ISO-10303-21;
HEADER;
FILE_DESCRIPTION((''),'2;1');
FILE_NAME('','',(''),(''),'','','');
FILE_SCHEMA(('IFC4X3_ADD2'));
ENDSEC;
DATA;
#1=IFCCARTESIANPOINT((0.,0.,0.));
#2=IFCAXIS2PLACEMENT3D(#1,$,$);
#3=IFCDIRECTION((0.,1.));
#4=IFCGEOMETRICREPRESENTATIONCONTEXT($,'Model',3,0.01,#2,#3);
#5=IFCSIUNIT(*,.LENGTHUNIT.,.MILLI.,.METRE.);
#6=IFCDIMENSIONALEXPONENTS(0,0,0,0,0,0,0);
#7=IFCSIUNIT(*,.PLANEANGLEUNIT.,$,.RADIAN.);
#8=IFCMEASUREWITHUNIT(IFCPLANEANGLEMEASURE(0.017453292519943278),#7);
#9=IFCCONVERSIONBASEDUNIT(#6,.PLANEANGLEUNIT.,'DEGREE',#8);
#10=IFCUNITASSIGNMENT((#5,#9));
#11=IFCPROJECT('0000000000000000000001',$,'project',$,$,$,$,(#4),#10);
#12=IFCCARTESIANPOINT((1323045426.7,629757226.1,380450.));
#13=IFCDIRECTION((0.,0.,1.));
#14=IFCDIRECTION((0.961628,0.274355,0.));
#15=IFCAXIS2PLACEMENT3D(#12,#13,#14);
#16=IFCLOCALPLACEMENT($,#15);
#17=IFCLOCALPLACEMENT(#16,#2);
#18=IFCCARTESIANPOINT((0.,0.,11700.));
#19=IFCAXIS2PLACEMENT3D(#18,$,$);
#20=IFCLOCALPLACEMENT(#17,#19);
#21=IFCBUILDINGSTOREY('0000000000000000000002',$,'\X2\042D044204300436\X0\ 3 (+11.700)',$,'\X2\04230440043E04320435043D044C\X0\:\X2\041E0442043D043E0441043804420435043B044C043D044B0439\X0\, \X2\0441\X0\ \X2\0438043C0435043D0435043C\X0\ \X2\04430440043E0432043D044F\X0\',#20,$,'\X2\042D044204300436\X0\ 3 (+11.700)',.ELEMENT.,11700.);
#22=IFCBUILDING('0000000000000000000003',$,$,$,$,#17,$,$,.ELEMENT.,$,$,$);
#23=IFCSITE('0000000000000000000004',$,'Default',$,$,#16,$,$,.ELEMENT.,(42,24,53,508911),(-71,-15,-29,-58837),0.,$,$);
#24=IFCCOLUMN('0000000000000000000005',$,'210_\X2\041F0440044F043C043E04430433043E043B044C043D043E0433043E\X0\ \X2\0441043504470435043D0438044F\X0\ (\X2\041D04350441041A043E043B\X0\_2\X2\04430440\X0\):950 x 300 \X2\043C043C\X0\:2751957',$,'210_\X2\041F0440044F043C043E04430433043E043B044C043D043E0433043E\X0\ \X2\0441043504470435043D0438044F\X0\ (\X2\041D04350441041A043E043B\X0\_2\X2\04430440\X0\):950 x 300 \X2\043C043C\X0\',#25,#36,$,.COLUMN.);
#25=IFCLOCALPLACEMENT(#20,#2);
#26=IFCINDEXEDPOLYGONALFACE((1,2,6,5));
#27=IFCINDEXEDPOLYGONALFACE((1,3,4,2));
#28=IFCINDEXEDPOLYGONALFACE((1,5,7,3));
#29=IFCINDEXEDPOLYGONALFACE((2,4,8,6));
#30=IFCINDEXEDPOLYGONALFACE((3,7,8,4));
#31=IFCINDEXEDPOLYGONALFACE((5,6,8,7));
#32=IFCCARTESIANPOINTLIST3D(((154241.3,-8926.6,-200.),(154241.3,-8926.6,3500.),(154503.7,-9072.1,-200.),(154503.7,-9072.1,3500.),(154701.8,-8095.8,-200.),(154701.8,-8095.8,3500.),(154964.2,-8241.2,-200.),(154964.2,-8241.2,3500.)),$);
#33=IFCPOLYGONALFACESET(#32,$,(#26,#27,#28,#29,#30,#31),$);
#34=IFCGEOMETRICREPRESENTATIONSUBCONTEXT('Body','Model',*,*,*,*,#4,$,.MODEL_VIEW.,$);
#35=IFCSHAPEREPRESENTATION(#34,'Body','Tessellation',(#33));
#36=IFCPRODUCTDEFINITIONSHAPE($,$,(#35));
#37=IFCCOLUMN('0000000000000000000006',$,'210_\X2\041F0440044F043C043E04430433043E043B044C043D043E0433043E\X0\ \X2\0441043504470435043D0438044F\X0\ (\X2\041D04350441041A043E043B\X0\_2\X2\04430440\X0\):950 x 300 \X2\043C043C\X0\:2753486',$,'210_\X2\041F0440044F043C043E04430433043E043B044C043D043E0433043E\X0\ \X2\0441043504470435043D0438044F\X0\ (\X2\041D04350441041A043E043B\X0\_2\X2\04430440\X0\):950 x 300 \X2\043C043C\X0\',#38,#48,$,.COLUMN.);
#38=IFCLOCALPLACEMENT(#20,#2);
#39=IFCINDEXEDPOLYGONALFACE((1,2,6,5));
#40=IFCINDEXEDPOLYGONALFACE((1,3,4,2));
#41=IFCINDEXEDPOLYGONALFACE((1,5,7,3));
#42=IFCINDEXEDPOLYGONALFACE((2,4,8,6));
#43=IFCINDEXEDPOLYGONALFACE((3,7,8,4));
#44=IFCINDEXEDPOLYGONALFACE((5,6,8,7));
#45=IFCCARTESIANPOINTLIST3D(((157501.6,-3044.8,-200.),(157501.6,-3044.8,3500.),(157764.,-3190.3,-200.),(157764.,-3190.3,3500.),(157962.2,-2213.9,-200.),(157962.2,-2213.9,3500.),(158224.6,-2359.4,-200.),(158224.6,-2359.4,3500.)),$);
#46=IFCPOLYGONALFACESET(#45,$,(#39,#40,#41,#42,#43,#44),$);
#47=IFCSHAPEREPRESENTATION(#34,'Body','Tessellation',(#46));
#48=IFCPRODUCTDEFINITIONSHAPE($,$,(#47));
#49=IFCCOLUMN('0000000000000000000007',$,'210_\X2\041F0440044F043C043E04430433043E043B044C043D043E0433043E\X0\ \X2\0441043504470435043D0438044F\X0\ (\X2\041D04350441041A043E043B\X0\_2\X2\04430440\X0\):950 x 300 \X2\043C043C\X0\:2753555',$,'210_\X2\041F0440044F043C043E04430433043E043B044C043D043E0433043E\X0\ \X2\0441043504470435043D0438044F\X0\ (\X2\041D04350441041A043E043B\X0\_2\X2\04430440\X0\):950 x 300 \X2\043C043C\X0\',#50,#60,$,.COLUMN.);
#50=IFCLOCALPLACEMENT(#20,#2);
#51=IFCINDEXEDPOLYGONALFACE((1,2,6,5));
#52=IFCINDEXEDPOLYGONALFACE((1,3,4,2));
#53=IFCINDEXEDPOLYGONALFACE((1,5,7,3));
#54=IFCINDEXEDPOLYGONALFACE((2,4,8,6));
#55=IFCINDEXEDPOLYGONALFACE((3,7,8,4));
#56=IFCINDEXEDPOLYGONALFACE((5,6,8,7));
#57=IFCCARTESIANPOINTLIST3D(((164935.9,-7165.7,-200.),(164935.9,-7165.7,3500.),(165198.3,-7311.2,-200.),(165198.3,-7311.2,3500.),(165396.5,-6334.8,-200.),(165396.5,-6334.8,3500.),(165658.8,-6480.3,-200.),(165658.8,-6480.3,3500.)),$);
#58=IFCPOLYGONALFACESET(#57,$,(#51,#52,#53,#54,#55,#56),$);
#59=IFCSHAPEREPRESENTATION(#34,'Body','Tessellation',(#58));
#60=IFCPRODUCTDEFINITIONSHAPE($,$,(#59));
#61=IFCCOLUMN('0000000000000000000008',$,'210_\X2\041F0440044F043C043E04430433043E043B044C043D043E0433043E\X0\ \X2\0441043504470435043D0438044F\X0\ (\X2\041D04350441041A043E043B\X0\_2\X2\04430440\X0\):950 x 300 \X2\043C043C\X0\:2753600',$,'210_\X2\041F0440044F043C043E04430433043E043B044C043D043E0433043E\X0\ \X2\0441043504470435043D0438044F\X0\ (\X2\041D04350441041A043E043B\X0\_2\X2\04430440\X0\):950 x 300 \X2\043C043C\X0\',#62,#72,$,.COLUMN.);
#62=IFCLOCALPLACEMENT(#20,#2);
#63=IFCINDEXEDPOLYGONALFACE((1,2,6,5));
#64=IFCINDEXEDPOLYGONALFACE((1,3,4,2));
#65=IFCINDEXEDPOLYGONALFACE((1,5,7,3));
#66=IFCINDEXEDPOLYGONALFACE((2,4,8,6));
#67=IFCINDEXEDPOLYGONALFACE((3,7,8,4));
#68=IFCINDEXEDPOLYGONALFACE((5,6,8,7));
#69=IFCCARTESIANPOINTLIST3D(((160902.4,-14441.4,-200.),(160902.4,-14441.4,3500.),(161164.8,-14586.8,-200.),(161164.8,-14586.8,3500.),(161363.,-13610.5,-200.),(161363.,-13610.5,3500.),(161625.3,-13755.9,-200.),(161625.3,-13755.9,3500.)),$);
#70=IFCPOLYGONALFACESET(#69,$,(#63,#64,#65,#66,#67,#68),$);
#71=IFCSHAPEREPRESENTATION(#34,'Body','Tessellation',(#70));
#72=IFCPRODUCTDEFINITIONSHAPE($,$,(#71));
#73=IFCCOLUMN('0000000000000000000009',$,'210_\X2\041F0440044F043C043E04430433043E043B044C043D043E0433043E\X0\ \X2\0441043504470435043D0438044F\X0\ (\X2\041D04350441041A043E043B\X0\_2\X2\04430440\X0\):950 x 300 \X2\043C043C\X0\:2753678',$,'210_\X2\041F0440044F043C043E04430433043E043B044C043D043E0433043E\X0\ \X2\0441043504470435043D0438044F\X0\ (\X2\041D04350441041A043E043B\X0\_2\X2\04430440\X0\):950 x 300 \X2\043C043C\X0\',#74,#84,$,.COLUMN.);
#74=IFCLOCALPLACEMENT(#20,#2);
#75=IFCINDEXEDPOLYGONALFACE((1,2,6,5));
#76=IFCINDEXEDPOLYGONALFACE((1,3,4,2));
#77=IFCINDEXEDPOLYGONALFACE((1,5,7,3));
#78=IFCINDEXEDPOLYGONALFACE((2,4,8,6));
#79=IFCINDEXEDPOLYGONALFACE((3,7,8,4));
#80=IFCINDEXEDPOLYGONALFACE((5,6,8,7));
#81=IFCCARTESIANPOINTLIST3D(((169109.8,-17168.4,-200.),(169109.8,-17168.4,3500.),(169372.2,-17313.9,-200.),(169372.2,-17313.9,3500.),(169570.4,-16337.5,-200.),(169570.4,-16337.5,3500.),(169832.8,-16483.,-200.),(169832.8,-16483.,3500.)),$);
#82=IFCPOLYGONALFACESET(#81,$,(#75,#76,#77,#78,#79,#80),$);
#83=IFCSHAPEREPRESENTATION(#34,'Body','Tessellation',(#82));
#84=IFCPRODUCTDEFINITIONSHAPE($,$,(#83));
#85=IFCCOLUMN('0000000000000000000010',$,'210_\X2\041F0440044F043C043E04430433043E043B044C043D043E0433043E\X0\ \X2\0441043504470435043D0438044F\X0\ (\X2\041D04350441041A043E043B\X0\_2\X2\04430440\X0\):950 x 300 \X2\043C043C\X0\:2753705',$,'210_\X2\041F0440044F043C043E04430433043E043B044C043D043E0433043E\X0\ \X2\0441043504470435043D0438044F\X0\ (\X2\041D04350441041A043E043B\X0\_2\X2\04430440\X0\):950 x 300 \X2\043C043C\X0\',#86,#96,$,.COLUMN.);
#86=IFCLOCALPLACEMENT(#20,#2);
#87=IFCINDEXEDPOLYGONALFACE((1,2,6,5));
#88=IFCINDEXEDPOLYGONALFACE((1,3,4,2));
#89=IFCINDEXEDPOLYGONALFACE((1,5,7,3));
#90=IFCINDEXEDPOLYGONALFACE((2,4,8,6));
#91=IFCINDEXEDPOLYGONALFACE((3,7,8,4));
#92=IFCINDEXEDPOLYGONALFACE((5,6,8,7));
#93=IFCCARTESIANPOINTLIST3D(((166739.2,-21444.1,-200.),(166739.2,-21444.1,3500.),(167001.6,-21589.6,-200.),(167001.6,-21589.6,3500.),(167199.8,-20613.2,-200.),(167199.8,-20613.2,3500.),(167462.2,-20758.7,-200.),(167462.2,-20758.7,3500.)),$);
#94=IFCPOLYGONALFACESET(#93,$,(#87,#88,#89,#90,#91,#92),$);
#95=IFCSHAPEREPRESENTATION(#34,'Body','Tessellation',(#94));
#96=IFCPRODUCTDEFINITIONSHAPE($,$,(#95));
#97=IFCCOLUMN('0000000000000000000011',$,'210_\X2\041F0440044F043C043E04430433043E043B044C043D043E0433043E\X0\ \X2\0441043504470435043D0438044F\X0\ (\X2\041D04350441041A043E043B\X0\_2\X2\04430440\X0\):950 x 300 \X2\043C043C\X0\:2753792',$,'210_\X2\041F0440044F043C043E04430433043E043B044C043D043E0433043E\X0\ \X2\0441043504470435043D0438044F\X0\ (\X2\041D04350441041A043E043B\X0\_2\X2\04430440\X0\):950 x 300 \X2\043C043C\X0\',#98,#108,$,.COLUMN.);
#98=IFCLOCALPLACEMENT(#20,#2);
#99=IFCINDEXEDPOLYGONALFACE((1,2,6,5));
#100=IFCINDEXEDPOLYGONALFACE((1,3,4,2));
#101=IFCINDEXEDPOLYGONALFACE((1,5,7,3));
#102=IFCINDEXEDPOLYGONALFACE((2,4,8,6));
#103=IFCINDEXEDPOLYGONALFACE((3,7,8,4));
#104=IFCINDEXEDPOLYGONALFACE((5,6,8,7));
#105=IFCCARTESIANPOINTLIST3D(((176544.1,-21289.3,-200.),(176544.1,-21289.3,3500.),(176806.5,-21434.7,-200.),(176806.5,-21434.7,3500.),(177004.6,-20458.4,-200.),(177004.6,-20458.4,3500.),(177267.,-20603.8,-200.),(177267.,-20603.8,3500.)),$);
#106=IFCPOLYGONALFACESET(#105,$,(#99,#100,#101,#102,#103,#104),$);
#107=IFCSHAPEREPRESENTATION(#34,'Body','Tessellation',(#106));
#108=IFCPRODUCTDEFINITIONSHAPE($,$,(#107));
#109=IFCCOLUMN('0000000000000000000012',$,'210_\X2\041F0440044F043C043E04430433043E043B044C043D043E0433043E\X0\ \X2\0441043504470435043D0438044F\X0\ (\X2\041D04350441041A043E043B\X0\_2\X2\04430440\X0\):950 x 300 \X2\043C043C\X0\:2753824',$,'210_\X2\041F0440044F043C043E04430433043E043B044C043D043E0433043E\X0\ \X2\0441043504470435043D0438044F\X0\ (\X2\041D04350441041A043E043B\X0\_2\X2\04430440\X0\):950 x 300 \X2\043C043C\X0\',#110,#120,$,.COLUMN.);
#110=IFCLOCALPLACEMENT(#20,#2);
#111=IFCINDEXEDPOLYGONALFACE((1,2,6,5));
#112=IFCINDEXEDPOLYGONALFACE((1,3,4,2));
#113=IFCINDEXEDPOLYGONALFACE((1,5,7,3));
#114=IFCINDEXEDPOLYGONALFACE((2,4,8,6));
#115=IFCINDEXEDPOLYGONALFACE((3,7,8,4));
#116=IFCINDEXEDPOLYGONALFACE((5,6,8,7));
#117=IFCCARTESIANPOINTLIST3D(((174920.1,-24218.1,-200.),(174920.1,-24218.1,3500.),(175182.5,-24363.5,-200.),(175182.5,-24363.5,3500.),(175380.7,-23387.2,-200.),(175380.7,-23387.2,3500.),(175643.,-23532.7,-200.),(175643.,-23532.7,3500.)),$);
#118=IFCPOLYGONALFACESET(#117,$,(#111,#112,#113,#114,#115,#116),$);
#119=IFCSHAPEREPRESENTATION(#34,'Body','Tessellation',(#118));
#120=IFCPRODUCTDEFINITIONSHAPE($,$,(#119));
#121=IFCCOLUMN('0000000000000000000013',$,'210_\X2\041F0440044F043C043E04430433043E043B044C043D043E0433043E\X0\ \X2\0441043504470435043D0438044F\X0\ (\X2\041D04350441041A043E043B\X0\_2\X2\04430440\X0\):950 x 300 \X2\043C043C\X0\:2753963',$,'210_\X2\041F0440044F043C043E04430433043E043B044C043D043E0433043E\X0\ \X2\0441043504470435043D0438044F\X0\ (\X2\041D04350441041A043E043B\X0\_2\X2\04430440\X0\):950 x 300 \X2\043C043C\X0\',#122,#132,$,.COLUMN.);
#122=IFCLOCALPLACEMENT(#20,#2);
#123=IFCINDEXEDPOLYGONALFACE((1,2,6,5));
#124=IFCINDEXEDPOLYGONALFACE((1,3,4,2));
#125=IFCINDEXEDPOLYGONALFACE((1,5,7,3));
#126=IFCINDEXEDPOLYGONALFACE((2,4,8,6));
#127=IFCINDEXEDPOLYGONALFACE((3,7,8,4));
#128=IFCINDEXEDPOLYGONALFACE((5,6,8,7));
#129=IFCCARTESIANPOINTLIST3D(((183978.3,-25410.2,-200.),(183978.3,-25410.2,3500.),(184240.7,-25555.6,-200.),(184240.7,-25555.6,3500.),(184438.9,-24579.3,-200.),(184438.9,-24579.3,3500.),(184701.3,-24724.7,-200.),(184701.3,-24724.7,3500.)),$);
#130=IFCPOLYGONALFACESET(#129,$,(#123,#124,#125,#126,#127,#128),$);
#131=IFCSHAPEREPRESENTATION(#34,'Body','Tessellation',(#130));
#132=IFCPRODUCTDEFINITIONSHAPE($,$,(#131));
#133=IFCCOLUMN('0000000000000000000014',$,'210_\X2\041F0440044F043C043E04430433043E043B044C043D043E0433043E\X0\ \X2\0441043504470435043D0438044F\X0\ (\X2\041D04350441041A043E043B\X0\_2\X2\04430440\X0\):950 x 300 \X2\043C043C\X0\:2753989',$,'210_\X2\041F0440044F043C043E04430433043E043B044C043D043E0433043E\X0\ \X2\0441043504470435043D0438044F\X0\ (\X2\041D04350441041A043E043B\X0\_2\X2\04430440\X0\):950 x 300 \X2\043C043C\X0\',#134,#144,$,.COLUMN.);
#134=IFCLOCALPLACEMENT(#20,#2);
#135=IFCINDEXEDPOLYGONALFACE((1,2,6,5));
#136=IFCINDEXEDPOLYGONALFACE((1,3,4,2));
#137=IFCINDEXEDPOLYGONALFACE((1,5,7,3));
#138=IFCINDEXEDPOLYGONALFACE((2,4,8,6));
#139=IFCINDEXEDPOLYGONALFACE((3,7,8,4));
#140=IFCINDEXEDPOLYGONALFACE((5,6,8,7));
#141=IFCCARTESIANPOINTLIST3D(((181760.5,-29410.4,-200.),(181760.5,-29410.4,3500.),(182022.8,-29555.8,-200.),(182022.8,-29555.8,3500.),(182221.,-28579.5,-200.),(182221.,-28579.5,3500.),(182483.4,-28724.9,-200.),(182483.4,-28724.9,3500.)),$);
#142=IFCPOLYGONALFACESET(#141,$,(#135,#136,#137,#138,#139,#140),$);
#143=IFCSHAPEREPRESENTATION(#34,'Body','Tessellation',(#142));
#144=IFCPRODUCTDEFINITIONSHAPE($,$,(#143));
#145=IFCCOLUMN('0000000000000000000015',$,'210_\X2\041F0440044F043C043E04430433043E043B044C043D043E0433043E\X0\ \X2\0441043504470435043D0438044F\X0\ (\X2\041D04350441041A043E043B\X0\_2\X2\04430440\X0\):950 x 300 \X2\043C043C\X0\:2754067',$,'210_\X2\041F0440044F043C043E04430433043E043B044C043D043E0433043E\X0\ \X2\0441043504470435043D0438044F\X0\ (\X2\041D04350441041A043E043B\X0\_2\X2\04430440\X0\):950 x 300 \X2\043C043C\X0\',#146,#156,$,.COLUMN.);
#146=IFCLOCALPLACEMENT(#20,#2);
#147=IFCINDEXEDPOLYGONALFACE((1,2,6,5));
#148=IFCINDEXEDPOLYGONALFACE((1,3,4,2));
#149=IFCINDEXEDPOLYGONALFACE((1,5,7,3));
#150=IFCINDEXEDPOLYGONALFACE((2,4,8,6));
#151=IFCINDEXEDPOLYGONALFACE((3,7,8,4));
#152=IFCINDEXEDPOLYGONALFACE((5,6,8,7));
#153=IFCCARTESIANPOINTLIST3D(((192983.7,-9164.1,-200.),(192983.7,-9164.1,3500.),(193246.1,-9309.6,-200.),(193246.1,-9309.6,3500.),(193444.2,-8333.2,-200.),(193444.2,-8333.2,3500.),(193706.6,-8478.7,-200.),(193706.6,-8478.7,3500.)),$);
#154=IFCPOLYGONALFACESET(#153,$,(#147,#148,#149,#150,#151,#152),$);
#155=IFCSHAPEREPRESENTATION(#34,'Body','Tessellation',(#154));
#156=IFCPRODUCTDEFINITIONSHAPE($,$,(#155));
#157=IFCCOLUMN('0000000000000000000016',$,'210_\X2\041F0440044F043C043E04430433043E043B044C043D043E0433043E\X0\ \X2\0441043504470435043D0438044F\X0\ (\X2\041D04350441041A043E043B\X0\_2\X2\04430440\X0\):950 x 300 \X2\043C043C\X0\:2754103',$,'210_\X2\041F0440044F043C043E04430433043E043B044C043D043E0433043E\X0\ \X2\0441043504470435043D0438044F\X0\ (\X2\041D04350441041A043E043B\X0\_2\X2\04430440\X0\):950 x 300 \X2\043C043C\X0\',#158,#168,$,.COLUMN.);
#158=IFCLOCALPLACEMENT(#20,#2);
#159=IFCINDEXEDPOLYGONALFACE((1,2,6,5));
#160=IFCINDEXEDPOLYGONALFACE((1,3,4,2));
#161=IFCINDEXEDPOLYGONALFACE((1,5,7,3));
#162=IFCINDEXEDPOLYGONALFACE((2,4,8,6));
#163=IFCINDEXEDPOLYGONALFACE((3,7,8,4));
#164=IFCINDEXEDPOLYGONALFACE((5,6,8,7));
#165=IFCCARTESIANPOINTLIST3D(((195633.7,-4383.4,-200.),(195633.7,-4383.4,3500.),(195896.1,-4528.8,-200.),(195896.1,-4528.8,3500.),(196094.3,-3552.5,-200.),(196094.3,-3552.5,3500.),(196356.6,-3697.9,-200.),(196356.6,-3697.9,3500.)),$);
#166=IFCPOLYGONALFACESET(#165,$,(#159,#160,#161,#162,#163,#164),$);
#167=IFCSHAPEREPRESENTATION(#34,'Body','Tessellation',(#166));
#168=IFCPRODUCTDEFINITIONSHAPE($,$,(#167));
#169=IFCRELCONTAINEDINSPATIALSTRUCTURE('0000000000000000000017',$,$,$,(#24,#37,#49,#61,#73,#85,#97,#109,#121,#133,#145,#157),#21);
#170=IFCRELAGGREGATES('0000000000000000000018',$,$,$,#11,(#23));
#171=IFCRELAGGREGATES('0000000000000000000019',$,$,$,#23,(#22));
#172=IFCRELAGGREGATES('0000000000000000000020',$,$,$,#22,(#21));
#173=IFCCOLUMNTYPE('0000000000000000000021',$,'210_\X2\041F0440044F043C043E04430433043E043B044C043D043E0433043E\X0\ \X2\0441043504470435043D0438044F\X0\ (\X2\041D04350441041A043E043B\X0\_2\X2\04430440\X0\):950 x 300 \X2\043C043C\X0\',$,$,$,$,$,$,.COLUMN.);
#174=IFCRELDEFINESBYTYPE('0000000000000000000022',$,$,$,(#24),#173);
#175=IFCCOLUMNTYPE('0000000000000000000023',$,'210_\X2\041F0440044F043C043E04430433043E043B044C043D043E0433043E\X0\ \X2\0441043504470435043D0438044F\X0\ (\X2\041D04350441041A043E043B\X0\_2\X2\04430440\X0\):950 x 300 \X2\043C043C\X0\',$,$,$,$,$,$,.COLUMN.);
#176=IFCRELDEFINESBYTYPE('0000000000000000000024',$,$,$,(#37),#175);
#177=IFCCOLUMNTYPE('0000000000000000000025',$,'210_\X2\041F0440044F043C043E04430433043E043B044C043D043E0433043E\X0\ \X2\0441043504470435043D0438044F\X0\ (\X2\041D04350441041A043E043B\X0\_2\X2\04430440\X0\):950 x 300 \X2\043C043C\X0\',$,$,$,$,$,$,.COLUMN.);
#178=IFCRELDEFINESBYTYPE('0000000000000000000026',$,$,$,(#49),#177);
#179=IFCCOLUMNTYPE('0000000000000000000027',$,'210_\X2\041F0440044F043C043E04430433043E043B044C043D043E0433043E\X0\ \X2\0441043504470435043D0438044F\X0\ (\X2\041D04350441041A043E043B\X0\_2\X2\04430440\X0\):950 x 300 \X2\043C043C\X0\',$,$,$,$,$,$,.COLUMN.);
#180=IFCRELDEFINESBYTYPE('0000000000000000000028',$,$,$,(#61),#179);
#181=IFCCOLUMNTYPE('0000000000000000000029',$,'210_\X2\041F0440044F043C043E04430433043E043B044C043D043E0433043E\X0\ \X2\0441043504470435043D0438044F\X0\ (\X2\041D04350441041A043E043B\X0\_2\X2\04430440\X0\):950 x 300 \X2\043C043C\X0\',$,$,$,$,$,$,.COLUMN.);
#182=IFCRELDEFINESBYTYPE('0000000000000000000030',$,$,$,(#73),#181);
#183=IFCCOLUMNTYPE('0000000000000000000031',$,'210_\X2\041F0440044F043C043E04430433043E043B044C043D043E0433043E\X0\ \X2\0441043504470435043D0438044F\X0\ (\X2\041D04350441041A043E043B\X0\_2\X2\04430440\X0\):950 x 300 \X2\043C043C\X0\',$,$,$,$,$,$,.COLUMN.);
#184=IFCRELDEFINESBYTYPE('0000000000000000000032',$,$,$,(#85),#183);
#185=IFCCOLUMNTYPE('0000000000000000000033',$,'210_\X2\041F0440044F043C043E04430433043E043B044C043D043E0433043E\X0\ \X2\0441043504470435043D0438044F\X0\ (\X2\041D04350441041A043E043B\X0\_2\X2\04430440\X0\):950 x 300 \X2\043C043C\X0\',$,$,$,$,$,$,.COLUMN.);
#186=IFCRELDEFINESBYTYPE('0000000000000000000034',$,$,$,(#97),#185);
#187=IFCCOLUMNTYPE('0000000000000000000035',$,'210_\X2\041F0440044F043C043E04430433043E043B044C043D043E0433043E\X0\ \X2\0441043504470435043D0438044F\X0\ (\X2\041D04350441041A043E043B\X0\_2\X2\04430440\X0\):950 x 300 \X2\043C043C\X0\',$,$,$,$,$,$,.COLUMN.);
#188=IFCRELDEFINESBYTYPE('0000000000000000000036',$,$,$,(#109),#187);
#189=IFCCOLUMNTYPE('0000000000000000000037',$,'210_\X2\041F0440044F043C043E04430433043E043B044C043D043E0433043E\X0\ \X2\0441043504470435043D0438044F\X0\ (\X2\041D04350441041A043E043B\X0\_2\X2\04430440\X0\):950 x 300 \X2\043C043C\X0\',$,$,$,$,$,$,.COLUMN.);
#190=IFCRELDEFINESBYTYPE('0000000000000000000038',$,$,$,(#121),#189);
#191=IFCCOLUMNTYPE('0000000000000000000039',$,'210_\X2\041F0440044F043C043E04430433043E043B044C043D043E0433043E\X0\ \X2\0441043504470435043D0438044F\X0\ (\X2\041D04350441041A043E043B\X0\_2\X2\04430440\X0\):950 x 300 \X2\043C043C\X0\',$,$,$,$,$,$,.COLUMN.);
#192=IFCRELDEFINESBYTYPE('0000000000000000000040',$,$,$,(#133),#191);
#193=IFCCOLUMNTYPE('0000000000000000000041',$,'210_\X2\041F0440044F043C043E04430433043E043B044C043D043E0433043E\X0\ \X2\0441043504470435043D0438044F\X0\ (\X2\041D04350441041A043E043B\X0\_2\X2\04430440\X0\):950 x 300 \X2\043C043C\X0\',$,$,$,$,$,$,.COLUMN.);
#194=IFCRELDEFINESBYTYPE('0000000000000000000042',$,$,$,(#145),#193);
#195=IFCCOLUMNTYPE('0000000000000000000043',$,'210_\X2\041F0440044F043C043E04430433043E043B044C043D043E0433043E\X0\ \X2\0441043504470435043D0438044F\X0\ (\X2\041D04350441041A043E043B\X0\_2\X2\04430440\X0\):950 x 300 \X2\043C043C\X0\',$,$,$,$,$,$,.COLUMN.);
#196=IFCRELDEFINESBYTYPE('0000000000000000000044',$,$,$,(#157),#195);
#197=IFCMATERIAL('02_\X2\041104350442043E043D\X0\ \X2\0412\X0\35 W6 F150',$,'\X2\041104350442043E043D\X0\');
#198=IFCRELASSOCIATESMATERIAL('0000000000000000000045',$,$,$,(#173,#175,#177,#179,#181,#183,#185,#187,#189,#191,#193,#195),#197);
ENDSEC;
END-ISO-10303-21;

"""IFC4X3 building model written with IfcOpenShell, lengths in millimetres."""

from ifc_helpers import new_model, entity, si_unit, converted_unit, direction, frame, frame_2d, origin, origin_2d_with_axis, place, context, subcontext, project, spatial, rectangle, extrude, source, transform, mapped, material, material_profile, profile_set, type_object, type_shapes, element, save


model = new_model("IFC4X3")

# Units and contexts
model_context = context("Model", 3, precision=0.01, world=origin(), true_north=direction((0.0, 1.0)))
body_context = subcontext(model_context, "Body", "Model", "MODEL_VIEW")
ifc_project = project(units=[si_unit("LENGTHUNIT", "METRE", prefix="MILLI"), converted_unit("PLANEANGLEUNIT", "DEGREE", entity("IfcPlaneAngleMeasure", 0.017453292519943278), si_unit("PLANEANGLEUNIT", "RADIAN"), dimensions=[0, 0, 0, 0, 0, 0, 0])], contexts=[model_context])

# Site, building, storey
site_placement = place(None, frame((1323045426.7, 629757226.1, 380450.0), z_axis=(0.0, 0.0, 1.0), x_axis=(0.961628, 0.274355, 0.0)))
site = spatial("IfcSite", under=ifc_project, at=site_placement, Name="Default", CompositionType="ELEMENT", RefLatitude=(42, 24, 53, 508911), RefLongitude=(-71, -15, -29, -58837), RefElevation=0.0)
building_placement = place(site_placement, origin())
building = spatial("IfcBuilding", under=site, at=building_placement, CompositionType="ELEMENT")
storey_placement = place(building_placement, frame((0.0, 0.0, 11700.0)))
storey = spatial("IfcBuildingStorey", under=building, at=storey_placement, Name="Этаж 3 (+11.700)", ObjectType="Уровень:Относительный, с именем уровня", LongName="Этаж 3 (+11.700)", CompositionType="ELEMENT", Elevation=11700.0)

# Columns
ifc_material = material(Name="02_Бетон В35 W6 F150", Category="Бетон")
ifc_material_profile_1 = material_profile(ifc_material, rectangle(XDim=300.0, YDim=950.0, at=frame_2d((0.0, 0.0), x_axis=(1.0, 0.0))), Name="950 x 300 мм")
ifc_profile_set_1 = profile_set([ifc_material_profile_1], Name="950 x 300 мм")
column_type_1 = type_object("IfcColumnType", Name="210_Прямоугольного сечения (НесКол_2ур):950 x 300 мм", PredefinedType="COLUMN", material=ifc_profile_set_1)
shared_shape_1 = source(origin(), body_context, "Body", "SweptSolid", [
    extrude(rectangle(XDim=300.0, YDim=950.0, at=frame_2d((0.0, 0.0), x_axis=(1.0, 0.0))), frame((154602.7, -8583.9, 11500.0), z_axis=(0.0, 0.0, 1.0), x_axis=(-0.87462, 0.48481, 0.0)), (0.0, 0.0, 1.0), 3700.0),
])
type_shapes(column_type_1, [shared_shape_1])
column_1_placement = place(storey_placement, frame((0.0, 0.0, -11700.0)))
element("IfcColumn", 1, at=column_1_placement, inside=storey, type_object=column_type_1, Name="210_Прямоугольного сечения (НесКол_2ур):950 x 300 мм:2751957", ObjectType="210_Прямоугольного сечения (НесКол_2ур):950 x 300 мм", PredefinedType="COLUMN", context=body_context, shape_type="MappedRepresentation", body=[
    mapped(shared_shape_1, transform((0.0, 0.0, 0.0), scale=1.0)),
])
column_type_2 = type_object("IfcColumnType", Name="210_Прямоугольного сечения (НесКол_2ур):950 x 300 мм", PredefinedType="COLUMN", material=ifc_profile_set_1)
shared_shape_2 = source(origin(), body_context, "Body", "SweptSolid", [
    extrude(rectangle(XDim=300.0, YDim=950.0, at=frame_2d((0.0, 0.0), x_axis=(1.0, 0.0))), frame((157863.1, -2702.1, 11500.0), z_axis=(0.0, 0.0, 1.0), x_axis=(-0.87462, 0.48481, 0.0)), (0.0, 0.0, 1.0), 3700.0),
])
type_shapes(column_type_2, [shared_shape_2])
column_2_placement = place(storey_placement, frame((0.0, 0.0, -11700.0)))
element("IfcColumn", 2, at=column_2_placement, inside=storey, type_object=column_type_2, Name="210_Прямоугольного сечения (НесКол_2ур):950 x 300 мм:2753486", ObjectType="210_Прямоугольного сечения (НесКол_2ур):950 x 300 мм", PredefinedType="COLUMN", context=body_context, shape_type="MappedRepresentation", body=[
    mapped(shared_shape_2, transform((0.0, 0.0, 0.0), scale=1.0)),
])
column_type_3 = type_object("IfcColumnType", Name="210_Прямоугольного сечения (НесКол_2ур):950 x 300 мм", PredefinedType="COLUMN", material=ifc_profile_set_1)
shared_shape_3 = source(origin(), body_context, "Body", "SweptSolid", [
    extrude(rectangle(XDim=300.0, YDim=950.0, at=frame_2d((0.0, 0.0), x_axis=(1.0, 0.0))), frame((165297.4, -6823.0, 11500.0), z_axis=(0.0, 0.0, 1.0), x_axis=(-0.87462, 0.48481, 0.0)), (0.0, 0.0, 1.0), 3700.0),
])
type_shapes(column_type_3, [shared_shape_3])
column_3_placement = place(storey_placement, frame((0.0, 0.0, -11700.0)))
element("IfcColumn", 3, at=column_3_placement, inside=storey, type_object=column_type_3, Name="210_Прямоугольного сечения (НесКол_2ур):950 x 300 мм:2753555", ObjectType="210_Прямоугольного сечения (НесКол_2ур):950 x 300 мм", PredefinedType="COLUMN", context=body_context, shape_type="MappedRepresentation", body=[
    mapped(shared_shape_3, transform((0.0, 0.0, 0.0), scale=1.0)),
])
column_type_4 = type_object("IfcColumnType", Name="210_Прямоугольного сечения (НесКол_2ур):950 x 300 мм", PredefinedType="COLUMN", material=ifc_profile_set_1)
shared_shape_4 = source(origin(), body_context, "Body", "SweptSolid", [
    extrude(rectangle(XDim=300.0, YDim=950.0, at=frame_2d((0.0, 0.0), x_axis=(1.0, 0.0))), frame((161263.9, -14098.7, 11500.0), z_axis=(0.0, 0.0, 1.0), x_axis=(-0.87462, 0.48481, 0.0)), (0.0, 0.0, 1.0), 3700.0),
])
type_shapes(column_type_4, [shared_shape_4])
column_4_placement = place(storey_placement, frame((0.0, 0.0, -11700.0)))
element("IfcColumn", 4, at=column_4_placement, inside=storey, type_object=column_type_4, Name="210_Прямоугольного сечения (НесКол_2ур):950 x 300 мм:2753600", ObjectType="210_Прямоугольного сечения (НесКол_2ур):950 x 300 мм", PredefinedType="COLUMN", context=body_context, shape_type="MappedRepresentation", body=[
    mapped(shared_shape_4, transform((0.0, 0.0, 0.0), scale=1.0)),
])
column_type_5 = type_object("IfcColumnType", Name="210_Прямоугольного сечения (НесКол_2ур):950 x 300 мм", PredefinedType="COLUMN", material=ifc_profile_set_1)
shared_shape_5 = source(origin(), body_context, "Body", "SweptSolid", [
    extrude(rectangle(XDim=300.0, YDim=950.0, at=origin_2d_with_axis()), frame((169471.3, -16825.7, 11500.0), z_axis=(0.0, 0.0, 1.0), x_axis=(-0.87462, 0.48481, 0.0)), (0.0, 0.0, 1.0), 3700.0),
])
type_shapes(column_type_5, [shared_shape_5])
column_5_placement = place(storey_placement, frame((0.0, 0.0, -11700.0)))
element("IfcColumn", 5, at=column_5_placement, inside=storey, type_object=column_type_5, Name="210_Прямоугольного сечения (НесКол_2ур):950 x 300 мм:2753678", ObjectType="210_Прямоугольного сечения (НесКол_2ур):950 x 300 мм", PredefinedType="COLUMN", context=body_context, shape_type="MappedRepresentation", body=[
    mapped(shared_shape_5, transform((0.0, 0.0, 0.0), scale=1.0)),
])
column_type_6 = type_object("IfcColumnType", Name="210_Прямоугольного сечения (НесКол_2ур):950 x 300 мм", PredefinedType="COLUMN", material=ifc_profile_set_1)
shared_shape_6 = source(origin(), body_context, "Body", "SweptSolid", [
    extrude(rectangle(XDim=300.0, YDim=950.0, at=origin_2d_with_axis()), frame((167100.7, -21101.4, 11500.0), z_axis=(0.0, 0.0, 1.0), x_axis=(-0.87462, 0.48481, 0.0)), (0.0, 0.0, 1.0), 3700.0),
])
type_shapes(column_type_6, [shared_shape_6])
column_6_placement = place(storey_placement, frame((0.0, 0.0, -11700.0)))
element("IfcColumn", 6, at=column_6_placement, inside=storey, type_object=column_type_6, Name="210_Прямоугольного сечения (НесКол_2ур):950 x 300 мм:2753705", ObjectType="210_Прямоугольного сечения (НесКол_2ур):950 x 300 мм", PredefinedType="COLUMN", context=body_context, shape_type="MappedRepresentation", body=[
    mapped(shared_shape_6, transform((0.0, 0.0, 0.0), scale=1.0)),
])
column_type_7 = type_object("IfcColumnType", Name="210_Прямоугольного сечения (НесКол_2ур):950 x 300 мм", PredefinedType="COLUMN", material=ifc_profile_set_1)
shared_shape_7 = source(origin(), body_context, "Body", "SweptSolid", [
    extrude(rectangle(XDim=300.0, YDim=950.0, at=frame_2d((0.0, 0.0), x_axis=(1.0, 0.0))), frame((176905.6, -20946.6, 11500.0), z_axis=(0.0, 0.0, 1.0), x_axis=(-0.87462, 0.48481, 0.0)), (0.0, 0.0, 1.0), 3700.0),
])
type_shapes(column_type_7, [shared_shape_7])
column_7_placement = place(storey_placement, frame((0.0, 0.0, -11700.0)))
element("IfcColumn", 7, at=column_7_placement, inside=storey, type_object=column_type_7, Name="210_Прямоугольного сечения (НесКол_2ур):950 x 300 мм:2753792", ObjectType="210_Прямоугольного сечения (НесКол_2ур):950 x 300 мм", PredefinedType="COLUMN", context=body_context, shape_type="MappedRepresentation", body=[
    mapped(shared_shape_7, transform((0.0, 0.0, 0.0), scale=1.0)),
])
column_type_8 = type_object("IfcColumnType", Name="210_Прямоугольного сечения (НесКол_2ур):950 x 300 мм", PredefinedType="COLUMN", material=ifc_profile_set_1)
shared_shape_8 = source(origin(), body_context, "Body", "SweptSolid", [
    extrude(rectangle(XDim=300.0, YDim=950.0, at=frame_2d((0.0, 0.0), x_axis=(1.0, 0.0))), frame((175281.6, -23875.4, 11500.0), z_axis=(0.0, 0.0, 1.0), x_axis=(-0.87462, 0.48481, 0.0)), (0.0, 0.0, 1.0), 3700.0),
])
type_shapes(column_type_8, [shared_shape_8])
column_8_placement = place(storey_placement, frame((0.0, 0.0, -11700.0)))
element("IfcColumn", 8, at=column_8_placement, inside=storey, type_object=column_type_8, Name="210_Прямоугольного сечения (НесКол_2ур):950 x 300 мм:2753824", ObjectType="210_Прямоугольного сечения (НесКол_2ур):950 x 300 мм", PredefinedType="COLUMN", context=body_context, shape_type="MappedRepresentation", body=[
    mapped(shared_shape_8, transform((0.0, 0.0, 0.0), scale=1.0)),
])
column_type_9 = type_object("IfcColumnType", Name="210_Прямоугольного сечения (НесКол_2ур):950 x 300 мм", PredefinedType="COLUMN", material=ifc_profile_set_1)
shared_shape_9 = source(origin(), body_context, "Body", "SweptSolid", [
    extrude(rectangle(XDim=300.0, YDim=950.0, at=frame_2d((0.0, 0.0), x_axis=(1.0, 0.0))), frame((184339.8, -25067.5, 11500.0), z_axis=(0.0, 0.0, 1.0), x_axis=(-0.87462, 0.48481, 0.0)), (0.0, 0.0, 1.0), 3700.0),
])
type_shapes(column_type_9, [shared_shape_9])
column_9_placement = place(storey_placement, frame((0.0, 0.0, -11700.0)))
element("IfcColumn", 9, at=column_9_placement, inside=storey, type_object=column_type_9, Name="210_Прямоугольного сечения (НесКол_2ур):950 x 300 мм:2753963", ObjectType="210_Прямоугольного сечения (НесКол_2ур):950 x 300 мм", PredefinedType="COLUMN", context=body_context, shape_type="MappedRepresentation", body=[
    mapped(shared_shape_9, transform((0.0, 0.0, 0.0), scale=1.0)),
])
column_type_10 = type_object("IfcColumnType", Name="210_Прямоугольного сечения (НесКол_2ур):950 x 300 мм", PredefinedType="COLUMN", material=ifc_profile_set_1)
shared_shape_10 = source(origin(), body_context, "Body", "SweptSolid", [
    extrude(rectangle(XDim=300.0, YDim=950.0, at=origin_2d_with_axis()), frame((182121.9, -29067.7, 11500.0), z_axis=(0.0, 0.0, 1.0), x_axis=(-0.87462, 0.48481, 0.0)), (0.0, 0.0, 1.0), 3700.0),
])
type_shapes(column_type_10, [shared_shape_10])
column_10_placement = place(storey_placement, frame((0.0, 0.0, -11700.0)))
element("IfcColumn", 10, at=column_10_placement, inside=storey, type_object=column_type_10, Name="210_Прямоугольного сечения (НесКол_2ур):950 x 300 мм:2753989", ObjectType="210_Прямоугольного сечения (НесКол_2ур):950 x 300 мм", PredefinedType="COLUMN", context=body_context, shape_type="MappedRepresentation", body=[
    mapped(shared_shape_10, transform((0.0, 0.0, 0.0), scale=1.0)),
])
column_type_11 = type_object("IfcColumnType", Name="210_Прямоугольного сечения (НесКол_2ур):950 x 300 мм", PredefinedType="COLUMN", material=ifc_profile_set_1)
shared_shape_11 = source(origin(), body_context, "Body", "SweptSolid", [
    extrude(rectangle(XDim=300.0, YDim=950.0, at=frame_2d((0.0, 0.0), x_axis=(1.0, 0.0))), frame((193345.2, -8821.4, 11500.0), z_axis=(0.0, 0.0, 1.0), x_axis=(-0.87462, 0.48481, 0.0)), (0.0, 0.0, 1.0), 3700.0),
])
type_shapes(column_type_11, [shared_shape_11])
column_11_placement = place(storey_placement, frame((0.0, 0.0, -11700.0)))
element("IfcColumn", 11, at=column_11_placement, inside=storey, type_object=column_type_11, Name="210_Прямоугольного сечения (НесКол_2ур):950 x 300 мм:2754067", ObjectType="210_Прямоугольного сечения (НесКол_2ур):950 x 300 мм", PredefinedType="COLUMN", context=body_context, shape_type="MappedRepresentation", body=[
    mapped(shared_shape_11, transform((0.0, 0.0, 0.0), scale=1.0)),
])
column_type_12 = type_object("IfcColumnType", Name="210_Прямоугольного сечения (НесКол_2ур):950 x 300 мм", PredefinedType="COLUMN", material=ifc_profile_set_1)
shared_shape_12 = source(origin(), body_context, "Body", "SweptSolid", [
    extrude(rectangle(XDim=300.0, YDim=950.0, at=frame_2d((0.0, 0.0), x_axis=(1.0, 0.0))), frame((195995.2, -4040.6, 11500.0), z_axis=(0.0, 0.0, 1.0), x_axis=(-0.87462, 0.48481, 0.0)), (0.0, 0.0, 1.0), 3700.0),
])
type_shapes(column_type_12, [shared_shape_12])
column_12_placement = place(storey_placement, frame((0.0, 0.0, -11700.0)))
element("IfcColumn", 12, at=column_12_placement, inside=storey, type_object=column_type_12, Name="210_Прямоугольного сечения (НесКол_2ур):950 x 300 мм:2754103", ObjectType="210_Прямоугольного сечения (НесКол_2ур):950 x 300 мм", PredefinedType="COLUMN", context=body_context, shape_type="MappedRepresentation", body=[
    mapped(shared_shape_12, transform((0.0, 0.0, 0.0), scale=1.0)),
])

save(model, "model.ifc")
